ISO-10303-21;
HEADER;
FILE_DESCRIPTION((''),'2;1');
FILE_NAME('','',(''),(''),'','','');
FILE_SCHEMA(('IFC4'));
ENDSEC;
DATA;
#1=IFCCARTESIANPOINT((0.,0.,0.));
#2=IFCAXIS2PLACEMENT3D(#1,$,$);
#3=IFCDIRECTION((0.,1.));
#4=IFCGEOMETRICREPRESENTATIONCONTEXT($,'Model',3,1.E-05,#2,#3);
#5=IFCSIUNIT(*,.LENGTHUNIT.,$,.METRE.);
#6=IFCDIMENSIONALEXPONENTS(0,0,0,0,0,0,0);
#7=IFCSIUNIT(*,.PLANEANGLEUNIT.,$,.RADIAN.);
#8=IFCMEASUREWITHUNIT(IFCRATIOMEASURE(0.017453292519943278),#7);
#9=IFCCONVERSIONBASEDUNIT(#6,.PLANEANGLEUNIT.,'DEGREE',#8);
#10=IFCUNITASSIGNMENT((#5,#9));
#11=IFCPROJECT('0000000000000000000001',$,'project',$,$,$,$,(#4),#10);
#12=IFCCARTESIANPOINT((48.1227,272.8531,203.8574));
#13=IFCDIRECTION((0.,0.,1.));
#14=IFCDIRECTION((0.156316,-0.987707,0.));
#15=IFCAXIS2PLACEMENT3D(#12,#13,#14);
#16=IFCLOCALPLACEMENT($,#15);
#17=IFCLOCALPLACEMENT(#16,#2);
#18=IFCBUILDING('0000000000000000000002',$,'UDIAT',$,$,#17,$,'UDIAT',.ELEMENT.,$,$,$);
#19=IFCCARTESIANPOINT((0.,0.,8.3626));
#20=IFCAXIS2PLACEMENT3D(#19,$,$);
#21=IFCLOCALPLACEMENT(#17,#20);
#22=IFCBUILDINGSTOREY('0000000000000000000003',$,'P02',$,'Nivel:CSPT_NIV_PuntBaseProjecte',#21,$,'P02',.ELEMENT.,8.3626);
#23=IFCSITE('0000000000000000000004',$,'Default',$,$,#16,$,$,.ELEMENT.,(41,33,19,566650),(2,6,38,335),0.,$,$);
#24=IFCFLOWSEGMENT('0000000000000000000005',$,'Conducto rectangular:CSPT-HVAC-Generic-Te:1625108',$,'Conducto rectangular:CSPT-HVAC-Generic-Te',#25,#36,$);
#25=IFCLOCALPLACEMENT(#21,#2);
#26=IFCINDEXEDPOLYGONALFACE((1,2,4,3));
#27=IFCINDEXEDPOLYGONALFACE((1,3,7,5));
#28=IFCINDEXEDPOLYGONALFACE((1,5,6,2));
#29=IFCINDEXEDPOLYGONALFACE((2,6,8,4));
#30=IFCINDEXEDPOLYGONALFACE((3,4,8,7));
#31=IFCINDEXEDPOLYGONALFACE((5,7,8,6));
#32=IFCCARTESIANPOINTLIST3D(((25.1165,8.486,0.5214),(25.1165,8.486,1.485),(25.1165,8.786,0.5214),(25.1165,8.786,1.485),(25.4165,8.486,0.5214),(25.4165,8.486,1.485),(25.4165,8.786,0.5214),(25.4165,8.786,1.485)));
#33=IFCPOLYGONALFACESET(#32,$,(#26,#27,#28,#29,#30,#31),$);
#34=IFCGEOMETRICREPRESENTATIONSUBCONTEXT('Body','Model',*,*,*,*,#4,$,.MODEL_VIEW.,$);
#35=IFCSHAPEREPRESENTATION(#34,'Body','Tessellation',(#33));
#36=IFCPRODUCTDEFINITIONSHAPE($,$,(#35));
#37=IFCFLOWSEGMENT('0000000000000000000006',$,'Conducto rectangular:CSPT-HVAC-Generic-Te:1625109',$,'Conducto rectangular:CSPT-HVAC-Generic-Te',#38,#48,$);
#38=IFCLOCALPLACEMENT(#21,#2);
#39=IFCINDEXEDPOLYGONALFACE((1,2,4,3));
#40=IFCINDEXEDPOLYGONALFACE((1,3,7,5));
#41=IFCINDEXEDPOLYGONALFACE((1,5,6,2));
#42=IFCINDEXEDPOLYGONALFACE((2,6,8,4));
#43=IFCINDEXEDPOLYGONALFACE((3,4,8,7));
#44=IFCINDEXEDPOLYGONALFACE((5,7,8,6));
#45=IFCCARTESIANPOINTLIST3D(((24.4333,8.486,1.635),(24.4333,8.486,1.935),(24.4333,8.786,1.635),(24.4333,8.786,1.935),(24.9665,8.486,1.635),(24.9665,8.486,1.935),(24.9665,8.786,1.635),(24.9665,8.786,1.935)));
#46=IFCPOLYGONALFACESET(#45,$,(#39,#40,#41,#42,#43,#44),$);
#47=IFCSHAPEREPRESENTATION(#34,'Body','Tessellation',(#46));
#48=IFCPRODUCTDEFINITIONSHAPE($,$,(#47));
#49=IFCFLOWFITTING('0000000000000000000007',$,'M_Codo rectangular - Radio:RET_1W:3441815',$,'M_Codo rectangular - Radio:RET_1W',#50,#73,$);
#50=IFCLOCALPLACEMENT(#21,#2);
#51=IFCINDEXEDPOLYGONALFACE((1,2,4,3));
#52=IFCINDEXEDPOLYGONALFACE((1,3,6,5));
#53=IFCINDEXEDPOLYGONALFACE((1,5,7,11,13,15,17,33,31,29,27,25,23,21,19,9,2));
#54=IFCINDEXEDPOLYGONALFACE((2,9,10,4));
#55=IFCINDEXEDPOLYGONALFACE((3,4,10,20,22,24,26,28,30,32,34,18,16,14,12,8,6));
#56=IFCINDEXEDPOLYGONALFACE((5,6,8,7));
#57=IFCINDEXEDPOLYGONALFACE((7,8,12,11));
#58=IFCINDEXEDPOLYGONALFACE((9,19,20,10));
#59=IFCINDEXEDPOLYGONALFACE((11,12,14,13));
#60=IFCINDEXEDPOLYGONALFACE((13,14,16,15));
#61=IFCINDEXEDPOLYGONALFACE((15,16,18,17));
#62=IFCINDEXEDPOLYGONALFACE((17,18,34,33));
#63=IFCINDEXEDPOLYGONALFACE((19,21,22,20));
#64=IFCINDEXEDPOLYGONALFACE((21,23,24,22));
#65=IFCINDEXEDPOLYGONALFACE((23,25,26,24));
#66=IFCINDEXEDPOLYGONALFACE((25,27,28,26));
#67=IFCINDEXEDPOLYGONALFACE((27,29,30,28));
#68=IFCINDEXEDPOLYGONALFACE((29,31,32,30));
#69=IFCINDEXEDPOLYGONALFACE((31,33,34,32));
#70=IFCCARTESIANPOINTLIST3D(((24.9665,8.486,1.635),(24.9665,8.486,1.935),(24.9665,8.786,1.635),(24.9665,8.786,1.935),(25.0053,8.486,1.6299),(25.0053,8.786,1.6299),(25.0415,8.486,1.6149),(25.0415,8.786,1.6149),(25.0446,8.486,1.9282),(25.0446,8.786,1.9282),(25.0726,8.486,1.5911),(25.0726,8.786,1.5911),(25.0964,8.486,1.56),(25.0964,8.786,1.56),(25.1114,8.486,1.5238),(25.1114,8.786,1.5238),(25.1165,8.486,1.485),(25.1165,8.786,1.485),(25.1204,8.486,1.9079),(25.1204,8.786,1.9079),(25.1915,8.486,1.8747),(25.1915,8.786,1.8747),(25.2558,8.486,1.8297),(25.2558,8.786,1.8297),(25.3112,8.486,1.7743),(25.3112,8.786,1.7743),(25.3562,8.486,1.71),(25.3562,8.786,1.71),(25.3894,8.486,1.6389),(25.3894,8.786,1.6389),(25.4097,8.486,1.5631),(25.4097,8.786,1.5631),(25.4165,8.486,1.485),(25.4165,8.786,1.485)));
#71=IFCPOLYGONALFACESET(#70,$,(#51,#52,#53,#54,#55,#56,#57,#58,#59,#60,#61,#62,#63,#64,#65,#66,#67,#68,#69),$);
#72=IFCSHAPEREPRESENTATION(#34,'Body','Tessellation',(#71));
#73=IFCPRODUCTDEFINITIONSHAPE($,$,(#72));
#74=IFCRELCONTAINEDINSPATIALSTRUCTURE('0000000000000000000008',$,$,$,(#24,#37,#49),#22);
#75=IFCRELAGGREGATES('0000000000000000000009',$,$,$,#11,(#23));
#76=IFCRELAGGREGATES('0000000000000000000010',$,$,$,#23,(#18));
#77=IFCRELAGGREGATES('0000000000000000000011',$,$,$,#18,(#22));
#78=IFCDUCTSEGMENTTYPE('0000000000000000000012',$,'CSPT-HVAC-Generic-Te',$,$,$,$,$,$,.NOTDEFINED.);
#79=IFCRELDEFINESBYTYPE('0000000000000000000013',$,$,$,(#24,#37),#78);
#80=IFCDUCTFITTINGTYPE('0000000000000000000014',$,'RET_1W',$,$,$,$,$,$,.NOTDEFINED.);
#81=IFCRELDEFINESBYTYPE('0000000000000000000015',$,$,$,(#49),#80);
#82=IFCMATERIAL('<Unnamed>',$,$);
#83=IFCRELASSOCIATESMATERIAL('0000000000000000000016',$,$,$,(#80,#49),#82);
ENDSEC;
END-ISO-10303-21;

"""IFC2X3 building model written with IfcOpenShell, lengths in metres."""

from ifc_helpers import new_model, entity, si_unit, converted_unit, direction, frame, frame_2d, origin, origin_2d_with_axis, place, context, subcontext, project, spatial, polyline, circle_curve, parameter, trimmed, segment, composite_curve, rectangle, outline, extrude, source, transform, mapped, material, type_object, type_shapes, element, save


model = new_model("IFC2X3")

# Units and contexts
model_context = context("Model", 3, precision=1e-05, world=origin(), true_north=direction((0.0, 1.0)))
body_context = subcontext(model_context, "Body", "Model", "MODEL_VIEW")
ifc_project = project(units=[si_unit("LENGTHUNIT", "METRE"), converted_unit("PLANEANGLEUNIT", "DEGREE", entity("IfcRatioMeasure", 0.017453292519943278), si_unit("PLANEANGLEUNIT", "RADIAN"), dimensions=[0, 0, 0, 0, 0, 0, 0])], contexts=[model_context])

# Site, building, storey
site_placement = place(None, frame((48.1227, 272.8531, 203.8574), z_axis=(0.0, 0.0, 1.0), x_axis=(0.156316, -0.987707, 0.0)))
site = spatial("IfcSite", under=ifc_project, at=site_placement, Name="Default", CompositionType="ELEMENT", RefLatitude=(41, 33, 19, 566650), RefLongitude=(2, 6, 38, 335), RefElevation=0.0)
building_placement = place(site_placement, origin())
building = spatial("IfcBuilding", under=site, at=building_placement, Name="UDIAT", LongName="UDIAT", CompositionType="ELEMENT")
storey_placement = place(building_placement, frame((0.0, 0.0, 8.3626)))
storey = spatial("IfcBuildingStorey", under=building, at=storey_placement, Name="P02", ObjectType="Nivel:CSPT_NIV_PuntBaseProjecte", LongName="P02", CompositionType="ELEMENT", Elevation=8.3626)

# Flow segments
duct_segment_type = type_object("IfcDuctSegmentType", Name="CSPT-HVAC-Generic-Te", PredefinedType="NOTDEFINED")
flow_segment_1_placement = place(storey_placement, origin())
element("IfcFlowSegment", 1, at=flow_segment_1_placement, inside=storey, type_object=duct_segment_type, Name="Conducto rectangular:CSPT-HVAC-Generic-Te:1625108", ObjectType="Conducto rectangular:CSPT-HVAC-Generic-Te", context=body_context, shape_type="SweptSolid", body=[
    extrude(rectangle(XDim=0.3, YDim=0.3, at=origin_2d_with_axis()), frame((25.2665, 8.636, 0.5214)), (0.0, 0.0, 1.0), 0.9636),
])
flow_segment_2_placement = place(storey_placement, origin())
element("IfcFlowSegment", 2, at=flow_segment_2_placement, inside=storey, type_object=duct_segment_type, Name="Conducto rectangular:CSPT-HVAC-Generic-Te:1625109", ObjectType="Conducto rectangular:CSPT-HVAC-Generic-Te", context=body_context, shape_type="SweptSolid", body=[
    extrude(rectangle(XDim=0.5332, YDim=0.3, at=frame_2d((0.0, 0.0), x_axis=(1.0, 0.0))), frame((24.6999, 8.636, 1.635), z_axis=(0.0, 0.0, 1.0), x_axis=(-1.0, 0.0, 0.0)), (0.0, 0.0, 1.0), 0.3),
])

# Flow fitting
ifc_material = material(Name="<Unnamed>")
duct_fitting_type = type_object("IfcDuctFittingType", Name="RET_1W", PredefinedType="NOTDEFINED", material=ifc_material)
shared_shape = source(origin(), body_context, "Body", "SweptSolid", [
    extrude(outline(composite_curve([segment(polyline([(-0.3, -0.15), (0.0, -0.15)]), True, "CONTINUOUS"), segment(trimmed(circle_curve(frame_2d((0.15, -0.15), x_axis=(0.0, 1.0)), 0.15), [parameter(0.0)], [parameter(90.0)], True, "PARAMETER"), False, "CONTINUOUS"), segment(polyline([(0.15, 0.0), (0.15, 0.3)]), True, "CONTINUOUS"), segment(trimmed(circle_curve(frame_2d((0.15, -0.15), x_axis=(0.0, 1.0)), 0.45), [parameter(0.0)], [parameter(90.0)], True, "PARAMETER"), True, "CONTINUOUS")], self_intersect=False)), frame((-0.15, 0.15, -0.15), z_axis=(0.0, 0.0, 1.0), x_axis=(-1.0, 0.0, 0.0)), (0.0, 0.0, 1.0), 0.3),
])
type_shapes(duct_fitting_type, [shared_shape])
flow_fitting_placement = place(storey_placement, frame((25.2665, 8.636, 1.785), z_axis=(0.0, -1.0, 0.0), x_axis=(0.0, 0.0, 1.0)))
element("IfcFlowFitting", 3, at=flow_fitting_placement, inside=storey, type_object=duct_fitting_type, material=ifc_material, Name="M_Codo rectangular - Radio:RET_1W:3441815", ObjectType="M_Codo rectangular - Radio:RET_1W", context=body_context, shape_type="MappedRepresentation", body=[
    mapped(shared_shape, transform((0.0, 0.0, 0.0), scale=1.0)),
])

save(model, "model.ifc")
